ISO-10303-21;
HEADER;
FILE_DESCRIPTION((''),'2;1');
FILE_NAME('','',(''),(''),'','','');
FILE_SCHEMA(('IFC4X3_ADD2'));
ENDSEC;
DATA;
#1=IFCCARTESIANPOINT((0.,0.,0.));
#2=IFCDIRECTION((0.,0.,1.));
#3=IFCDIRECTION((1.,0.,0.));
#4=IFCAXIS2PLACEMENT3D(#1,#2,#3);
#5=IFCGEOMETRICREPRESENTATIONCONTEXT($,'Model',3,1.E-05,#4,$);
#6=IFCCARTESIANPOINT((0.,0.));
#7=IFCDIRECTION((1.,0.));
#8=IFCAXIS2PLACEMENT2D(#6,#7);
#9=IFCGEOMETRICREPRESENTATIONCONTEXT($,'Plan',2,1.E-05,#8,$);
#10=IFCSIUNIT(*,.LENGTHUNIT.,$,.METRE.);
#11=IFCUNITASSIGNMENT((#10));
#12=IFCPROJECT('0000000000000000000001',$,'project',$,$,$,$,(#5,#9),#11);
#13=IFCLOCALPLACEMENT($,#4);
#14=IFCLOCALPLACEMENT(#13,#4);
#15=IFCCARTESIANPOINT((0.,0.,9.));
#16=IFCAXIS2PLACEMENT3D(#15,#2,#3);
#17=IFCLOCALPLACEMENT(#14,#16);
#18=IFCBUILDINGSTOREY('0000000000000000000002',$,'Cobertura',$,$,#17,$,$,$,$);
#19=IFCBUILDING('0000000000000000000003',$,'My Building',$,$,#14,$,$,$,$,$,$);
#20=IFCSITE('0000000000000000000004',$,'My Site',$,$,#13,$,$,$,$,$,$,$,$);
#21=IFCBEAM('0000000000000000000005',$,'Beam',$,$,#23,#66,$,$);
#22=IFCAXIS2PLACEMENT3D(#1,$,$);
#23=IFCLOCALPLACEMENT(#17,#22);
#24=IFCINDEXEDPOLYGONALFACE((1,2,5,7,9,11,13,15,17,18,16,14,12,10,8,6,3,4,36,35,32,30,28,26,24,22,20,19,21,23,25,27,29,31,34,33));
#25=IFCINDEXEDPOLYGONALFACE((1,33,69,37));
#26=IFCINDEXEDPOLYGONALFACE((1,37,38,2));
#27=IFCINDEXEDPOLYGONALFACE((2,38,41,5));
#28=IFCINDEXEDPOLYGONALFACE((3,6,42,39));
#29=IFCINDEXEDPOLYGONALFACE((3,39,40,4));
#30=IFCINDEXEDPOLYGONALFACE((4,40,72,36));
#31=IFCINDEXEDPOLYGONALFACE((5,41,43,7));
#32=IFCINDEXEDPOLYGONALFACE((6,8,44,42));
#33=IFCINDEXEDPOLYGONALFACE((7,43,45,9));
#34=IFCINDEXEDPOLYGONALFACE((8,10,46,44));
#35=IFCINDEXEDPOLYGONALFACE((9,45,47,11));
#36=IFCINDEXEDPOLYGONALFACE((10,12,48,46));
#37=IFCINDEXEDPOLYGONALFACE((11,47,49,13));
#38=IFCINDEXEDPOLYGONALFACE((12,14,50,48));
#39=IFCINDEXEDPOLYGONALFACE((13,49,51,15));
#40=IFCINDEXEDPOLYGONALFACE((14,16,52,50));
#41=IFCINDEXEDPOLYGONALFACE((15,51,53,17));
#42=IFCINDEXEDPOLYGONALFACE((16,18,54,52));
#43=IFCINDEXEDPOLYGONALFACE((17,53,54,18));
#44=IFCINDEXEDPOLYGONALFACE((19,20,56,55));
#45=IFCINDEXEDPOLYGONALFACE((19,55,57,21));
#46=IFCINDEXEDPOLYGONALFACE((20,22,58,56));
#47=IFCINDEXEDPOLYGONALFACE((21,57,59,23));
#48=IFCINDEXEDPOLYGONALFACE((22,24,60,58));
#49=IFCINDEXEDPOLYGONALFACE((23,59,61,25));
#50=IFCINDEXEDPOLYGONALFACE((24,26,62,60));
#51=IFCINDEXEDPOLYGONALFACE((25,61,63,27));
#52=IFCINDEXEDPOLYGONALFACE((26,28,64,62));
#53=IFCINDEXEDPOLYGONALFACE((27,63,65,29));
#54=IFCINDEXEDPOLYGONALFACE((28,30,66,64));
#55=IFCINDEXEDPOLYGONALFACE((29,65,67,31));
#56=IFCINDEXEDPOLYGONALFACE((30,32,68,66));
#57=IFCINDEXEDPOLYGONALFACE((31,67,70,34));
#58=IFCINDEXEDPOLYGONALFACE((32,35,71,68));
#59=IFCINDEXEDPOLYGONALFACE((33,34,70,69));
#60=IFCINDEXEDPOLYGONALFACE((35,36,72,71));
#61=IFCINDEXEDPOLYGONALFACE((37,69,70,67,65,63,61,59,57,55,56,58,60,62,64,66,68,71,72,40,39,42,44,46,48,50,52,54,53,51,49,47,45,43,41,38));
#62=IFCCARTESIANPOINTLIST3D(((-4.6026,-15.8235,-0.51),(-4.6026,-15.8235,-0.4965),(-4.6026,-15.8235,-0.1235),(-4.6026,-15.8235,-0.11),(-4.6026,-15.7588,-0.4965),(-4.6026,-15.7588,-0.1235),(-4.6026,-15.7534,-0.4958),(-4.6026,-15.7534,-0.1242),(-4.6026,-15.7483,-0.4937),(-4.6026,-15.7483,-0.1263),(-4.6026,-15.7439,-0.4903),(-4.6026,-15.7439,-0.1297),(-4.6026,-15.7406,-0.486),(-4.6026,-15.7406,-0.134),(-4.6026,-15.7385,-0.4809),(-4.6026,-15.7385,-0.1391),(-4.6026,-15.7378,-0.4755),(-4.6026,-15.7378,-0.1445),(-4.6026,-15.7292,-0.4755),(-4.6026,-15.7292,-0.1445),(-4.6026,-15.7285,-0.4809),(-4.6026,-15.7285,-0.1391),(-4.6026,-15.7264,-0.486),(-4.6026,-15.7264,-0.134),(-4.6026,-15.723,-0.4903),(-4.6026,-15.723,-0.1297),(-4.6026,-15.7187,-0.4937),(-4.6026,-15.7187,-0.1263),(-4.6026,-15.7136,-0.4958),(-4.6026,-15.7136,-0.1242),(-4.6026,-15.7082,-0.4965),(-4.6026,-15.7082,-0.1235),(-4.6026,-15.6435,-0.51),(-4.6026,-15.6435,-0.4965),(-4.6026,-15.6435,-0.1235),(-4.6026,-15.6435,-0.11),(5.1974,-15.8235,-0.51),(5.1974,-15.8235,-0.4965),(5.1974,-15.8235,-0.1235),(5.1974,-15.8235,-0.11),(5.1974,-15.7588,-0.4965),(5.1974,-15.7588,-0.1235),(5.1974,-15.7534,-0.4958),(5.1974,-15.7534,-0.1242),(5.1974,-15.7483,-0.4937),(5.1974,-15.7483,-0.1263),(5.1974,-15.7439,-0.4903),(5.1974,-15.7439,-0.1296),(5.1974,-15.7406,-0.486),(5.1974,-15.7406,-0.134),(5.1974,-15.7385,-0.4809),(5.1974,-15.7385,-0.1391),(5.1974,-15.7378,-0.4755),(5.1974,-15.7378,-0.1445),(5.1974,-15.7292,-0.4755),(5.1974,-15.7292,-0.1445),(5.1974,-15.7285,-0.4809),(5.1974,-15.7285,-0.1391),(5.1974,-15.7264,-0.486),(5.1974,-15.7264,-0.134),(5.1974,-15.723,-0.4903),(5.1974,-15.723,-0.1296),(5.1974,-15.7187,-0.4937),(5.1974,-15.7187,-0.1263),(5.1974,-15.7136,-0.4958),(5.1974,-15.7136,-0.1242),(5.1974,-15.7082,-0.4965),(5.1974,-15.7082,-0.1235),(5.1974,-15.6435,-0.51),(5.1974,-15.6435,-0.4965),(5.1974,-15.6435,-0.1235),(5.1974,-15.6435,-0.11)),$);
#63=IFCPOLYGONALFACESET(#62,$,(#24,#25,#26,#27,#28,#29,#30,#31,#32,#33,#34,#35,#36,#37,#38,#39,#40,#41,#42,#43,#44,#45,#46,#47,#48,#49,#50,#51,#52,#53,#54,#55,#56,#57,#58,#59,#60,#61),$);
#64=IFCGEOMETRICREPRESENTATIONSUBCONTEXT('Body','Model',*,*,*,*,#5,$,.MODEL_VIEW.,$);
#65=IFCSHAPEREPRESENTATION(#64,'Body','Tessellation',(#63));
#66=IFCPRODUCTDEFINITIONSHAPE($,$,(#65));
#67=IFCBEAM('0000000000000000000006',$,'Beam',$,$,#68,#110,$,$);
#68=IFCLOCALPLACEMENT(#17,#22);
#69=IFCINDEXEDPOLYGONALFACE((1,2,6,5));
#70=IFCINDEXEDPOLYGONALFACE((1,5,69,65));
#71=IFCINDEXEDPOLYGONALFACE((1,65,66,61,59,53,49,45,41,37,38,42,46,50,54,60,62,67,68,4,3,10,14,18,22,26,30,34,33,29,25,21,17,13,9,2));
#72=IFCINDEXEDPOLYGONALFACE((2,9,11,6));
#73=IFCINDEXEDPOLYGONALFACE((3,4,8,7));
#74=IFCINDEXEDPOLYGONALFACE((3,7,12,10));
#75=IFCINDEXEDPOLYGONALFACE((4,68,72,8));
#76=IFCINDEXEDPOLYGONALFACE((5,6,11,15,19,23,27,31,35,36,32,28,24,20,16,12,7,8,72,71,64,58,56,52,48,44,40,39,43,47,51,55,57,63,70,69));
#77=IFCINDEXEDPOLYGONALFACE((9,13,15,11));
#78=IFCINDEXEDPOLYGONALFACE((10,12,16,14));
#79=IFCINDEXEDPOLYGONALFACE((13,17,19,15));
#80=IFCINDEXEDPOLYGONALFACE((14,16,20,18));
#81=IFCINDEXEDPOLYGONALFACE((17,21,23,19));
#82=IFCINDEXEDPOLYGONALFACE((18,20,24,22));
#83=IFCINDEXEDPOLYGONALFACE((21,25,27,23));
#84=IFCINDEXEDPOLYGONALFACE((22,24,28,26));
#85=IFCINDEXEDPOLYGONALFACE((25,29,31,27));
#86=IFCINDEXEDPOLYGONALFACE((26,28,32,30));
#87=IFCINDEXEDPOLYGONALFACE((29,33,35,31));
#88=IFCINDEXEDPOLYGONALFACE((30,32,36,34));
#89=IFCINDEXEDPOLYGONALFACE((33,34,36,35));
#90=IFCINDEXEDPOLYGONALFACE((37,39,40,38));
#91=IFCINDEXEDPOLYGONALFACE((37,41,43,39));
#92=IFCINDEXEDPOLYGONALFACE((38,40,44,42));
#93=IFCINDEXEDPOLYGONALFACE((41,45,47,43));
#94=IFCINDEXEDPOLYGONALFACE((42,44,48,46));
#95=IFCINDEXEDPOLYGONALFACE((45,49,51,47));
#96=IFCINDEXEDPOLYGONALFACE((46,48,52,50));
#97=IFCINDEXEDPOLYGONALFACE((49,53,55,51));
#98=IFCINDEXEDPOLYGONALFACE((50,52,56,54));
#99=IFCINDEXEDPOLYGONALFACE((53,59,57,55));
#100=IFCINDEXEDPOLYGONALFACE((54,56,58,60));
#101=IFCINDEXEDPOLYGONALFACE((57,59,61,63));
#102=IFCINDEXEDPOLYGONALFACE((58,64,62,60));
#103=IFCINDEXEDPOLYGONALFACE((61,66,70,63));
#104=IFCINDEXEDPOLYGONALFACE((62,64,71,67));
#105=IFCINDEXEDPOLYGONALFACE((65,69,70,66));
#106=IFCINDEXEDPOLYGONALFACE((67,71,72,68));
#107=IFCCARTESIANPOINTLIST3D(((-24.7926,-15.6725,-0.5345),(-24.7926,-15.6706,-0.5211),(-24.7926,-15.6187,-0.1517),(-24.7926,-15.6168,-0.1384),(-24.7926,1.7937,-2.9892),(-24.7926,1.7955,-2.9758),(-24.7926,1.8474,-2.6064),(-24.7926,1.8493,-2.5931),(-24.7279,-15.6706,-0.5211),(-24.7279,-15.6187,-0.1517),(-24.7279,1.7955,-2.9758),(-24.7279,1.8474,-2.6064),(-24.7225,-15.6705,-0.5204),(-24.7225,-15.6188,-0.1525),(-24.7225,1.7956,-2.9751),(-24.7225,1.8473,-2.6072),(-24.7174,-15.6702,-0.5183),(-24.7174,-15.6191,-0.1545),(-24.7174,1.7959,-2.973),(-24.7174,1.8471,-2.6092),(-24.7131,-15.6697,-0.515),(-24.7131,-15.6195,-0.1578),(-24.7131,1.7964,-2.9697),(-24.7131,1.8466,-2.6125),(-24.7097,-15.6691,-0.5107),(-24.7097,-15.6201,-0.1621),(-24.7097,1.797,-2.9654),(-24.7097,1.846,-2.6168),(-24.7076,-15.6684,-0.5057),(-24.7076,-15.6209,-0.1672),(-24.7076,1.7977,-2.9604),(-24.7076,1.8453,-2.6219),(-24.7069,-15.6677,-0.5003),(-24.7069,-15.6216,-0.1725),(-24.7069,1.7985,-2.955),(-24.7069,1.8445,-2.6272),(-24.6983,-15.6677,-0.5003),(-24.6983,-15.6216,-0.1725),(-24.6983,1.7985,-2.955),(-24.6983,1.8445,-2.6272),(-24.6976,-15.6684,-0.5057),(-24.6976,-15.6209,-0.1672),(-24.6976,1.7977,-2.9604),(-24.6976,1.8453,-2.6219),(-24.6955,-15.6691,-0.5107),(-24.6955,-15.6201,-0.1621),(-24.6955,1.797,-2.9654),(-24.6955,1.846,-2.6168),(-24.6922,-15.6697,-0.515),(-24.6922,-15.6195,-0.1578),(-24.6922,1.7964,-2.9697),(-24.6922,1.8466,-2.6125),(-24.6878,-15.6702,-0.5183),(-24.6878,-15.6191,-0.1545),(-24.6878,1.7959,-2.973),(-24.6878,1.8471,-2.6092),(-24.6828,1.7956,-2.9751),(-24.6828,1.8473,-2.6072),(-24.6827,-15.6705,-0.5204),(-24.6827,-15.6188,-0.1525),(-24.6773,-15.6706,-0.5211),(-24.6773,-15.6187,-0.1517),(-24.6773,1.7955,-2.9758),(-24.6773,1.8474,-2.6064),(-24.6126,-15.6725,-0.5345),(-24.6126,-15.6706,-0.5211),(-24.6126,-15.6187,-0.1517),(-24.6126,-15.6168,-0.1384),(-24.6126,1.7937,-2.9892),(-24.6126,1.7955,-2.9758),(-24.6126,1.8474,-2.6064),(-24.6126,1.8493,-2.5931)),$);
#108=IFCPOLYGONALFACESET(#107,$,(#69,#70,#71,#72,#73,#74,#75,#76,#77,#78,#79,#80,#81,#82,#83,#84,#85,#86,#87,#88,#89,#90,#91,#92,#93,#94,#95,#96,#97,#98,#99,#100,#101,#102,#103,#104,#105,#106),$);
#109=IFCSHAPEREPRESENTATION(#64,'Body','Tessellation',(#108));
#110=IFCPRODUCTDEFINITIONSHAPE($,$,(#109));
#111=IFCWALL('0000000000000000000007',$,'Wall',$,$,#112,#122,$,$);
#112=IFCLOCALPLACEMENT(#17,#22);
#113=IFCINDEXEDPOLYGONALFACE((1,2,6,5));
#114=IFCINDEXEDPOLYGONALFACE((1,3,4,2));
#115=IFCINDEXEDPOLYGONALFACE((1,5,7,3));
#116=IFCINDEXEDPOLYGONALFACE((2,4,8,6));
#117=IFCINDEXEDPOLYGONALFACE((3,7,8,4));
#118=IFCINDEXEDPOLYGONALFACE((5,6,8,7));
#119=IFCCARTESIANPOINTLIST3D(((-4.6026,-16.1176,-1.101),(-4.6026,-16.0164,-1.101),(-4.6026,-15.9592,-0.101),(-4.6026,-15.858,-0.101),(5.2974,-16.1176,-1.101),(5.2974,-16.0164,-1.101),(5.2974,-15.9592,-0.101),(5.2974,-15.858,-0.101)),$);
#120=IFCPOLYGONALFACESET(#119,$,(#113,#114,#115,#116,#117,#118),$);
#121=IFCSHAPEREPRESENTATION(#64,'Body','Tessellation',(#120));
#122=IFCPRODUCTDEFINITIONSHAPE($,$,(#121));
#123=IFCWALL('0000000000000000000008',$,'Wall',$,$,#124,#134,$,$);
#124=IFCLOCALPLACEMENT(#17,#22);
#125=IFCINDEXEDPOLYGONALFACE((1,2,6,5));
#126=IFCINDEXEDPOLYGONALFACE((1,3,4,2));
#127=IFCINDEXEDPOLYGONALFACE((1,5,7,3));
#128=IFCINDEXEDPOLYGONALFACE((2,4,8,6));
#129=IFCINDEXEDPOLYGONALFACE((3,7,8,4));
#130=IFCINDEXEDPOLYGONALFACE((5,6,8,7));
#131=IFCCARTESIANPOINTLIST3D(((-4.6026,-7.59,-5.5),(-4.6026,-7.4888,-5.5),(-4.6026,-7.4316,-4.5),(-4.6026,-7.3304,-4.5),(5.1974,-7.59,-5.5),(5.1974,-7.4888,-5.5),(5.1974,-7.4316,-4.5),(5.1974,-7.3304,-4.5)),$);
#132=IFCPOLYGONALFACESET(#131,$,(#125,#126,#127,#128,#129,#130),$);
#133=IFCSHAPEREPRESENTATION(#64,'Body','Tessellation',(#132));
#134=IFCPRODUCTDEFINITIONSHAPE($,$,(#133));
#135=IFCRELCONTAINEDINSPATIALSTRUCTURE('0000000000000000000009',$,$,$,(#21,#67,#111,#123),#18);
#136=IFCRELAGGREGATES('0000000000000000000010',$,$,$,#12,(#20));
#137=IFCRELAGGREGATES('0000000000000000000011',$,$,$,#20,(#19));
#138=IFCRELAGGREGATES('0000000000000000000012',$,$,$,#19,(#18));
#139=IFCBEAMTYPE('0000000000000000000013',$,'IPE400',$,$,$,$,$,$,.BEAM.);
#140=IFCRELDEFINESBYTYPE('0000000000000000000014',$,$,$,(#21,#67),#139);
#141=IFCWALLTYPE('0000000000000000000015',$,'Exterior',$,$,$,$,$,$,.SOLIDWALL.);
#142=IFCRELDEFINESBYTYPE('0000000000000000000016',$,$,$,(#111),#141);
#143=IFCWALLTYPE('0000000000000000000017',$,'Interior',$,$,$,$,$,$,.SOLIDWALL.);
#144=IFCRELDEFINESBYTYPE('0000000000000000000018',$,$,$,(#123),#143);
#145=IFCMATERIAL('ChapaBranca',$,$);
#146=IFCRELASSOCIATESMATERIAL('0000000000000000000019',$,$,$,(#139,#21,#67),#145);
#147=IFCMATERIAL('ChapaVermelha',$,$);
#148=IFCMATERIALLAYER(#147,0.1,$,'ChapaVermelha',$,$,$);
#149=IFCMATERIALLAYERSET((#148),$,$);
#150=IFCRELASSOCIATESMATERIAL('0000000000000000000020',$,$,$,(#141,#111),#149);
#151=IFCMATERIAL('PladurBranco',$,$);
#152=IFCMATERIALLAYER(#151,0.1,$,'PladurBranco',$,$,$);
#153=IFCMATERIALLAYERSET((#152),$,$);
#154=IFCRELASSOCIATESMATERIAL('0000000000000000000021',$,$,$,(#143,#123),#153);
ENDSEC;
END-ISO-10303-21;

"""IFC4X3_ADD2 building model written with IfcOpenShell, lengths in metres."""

from ifc_helpers import new_model, si_unit, frame, origin_with_axes, origin_2d_with_axis, place, context, subcontext, project, spatial, line, indexed_curve, i_section, outline, extrude, boolean, material, layer, layer_set, layer_usage, material_profile, profile_set, profile_usage, type_object, element, save


model = new_model("IFC4X3_ADD2")

# Units and contexts
model_context = context("Model", 3, precision=1e-05, world=origin_with_axes())
plan_context = context("Plan", 2, precision=1e-05, world=origin_2d_with_axis())
body_context = subcontext(model_context, "Body", "Model", "MODEL_VIEW")
ifc_project = project(units=[si_unit("LENGTHUNIT", "METRE")], contexts=[model_context, plan_context])

# Site, building, storey
site_placement = place(None, origin_with_axes())
site = spatial("IfcSite", under=ifc_project, at=site_placement, Name="My Site")
building_placement = place(site_placement, origin_with_axes())
building = spatial("IfcBuilding", under=site, at=building_placement, Name="My Building")
storey_placement = place(building_placement, frame((0.0, 0.0, 9.0), z_axis=(0.0, 0.0, 1.0), x_axis=(1.0, 0.0, 0.0)))
storey = spatial("IfcBuildingStorey", under=building, at=storey_placement, Name="Cobertura")

# Beams
ifc_material_1 = material(Name="ChapaBranca")
ifc_material_profile = material_profile(ifc_material_1, i_section(OverallWidth=0.18, OverallDepth=0.4, WebThickness=0.0086, FlangeThickness=0.0135, FilletRadius=0.021))
ifc_profile_set = profile_set([ifc_material_profile])
ifc_profile_usage_1 = profile_usage(ifc_profile_set, cardinal=8)
beam_type = type_object("IfcBeamType", Name="IPE400", PredefinedType="BEAM", material=ifc_profile_set)
beam_1_placement = place(storey_placement, frame((-4.6026, -15.7335, -0.11), z_axis=(1.0, -0.000001, 0.000001), x_axis=(0.000001, 1.0, 0.0)))
element("IfcBeam", 1, at=beam_1_placement, inside=storey, type_object=beam_type, material=ifc_profile_usage_1, Name="Beam", context=body_context, shape_type="SweptSolid", body=[
    extrude(i_section(OverallWidth=0.18, OverallDepth=0.4, WebThickness=0.0086, FlangeThickness=0.0135, FilletRadius=0.021), frame((0.0, -0.2, 0.0), z_axis=(0.0, 0.0, 1.0), x_axis=(1.0, 0.0, 0.0)), (0.0, 0.0, 1.0), 9.8),
])
ifc_profile_usage_2 = profile_usage(ifc_profile_set, cardinal=8)
beam_2_placement = place(storey_placement, frame((-24.7026, -15.6168, -0.1384), z_axis=(0.0, 0.990268, -0.139173), x_axis=(-1.0, 0.0, 0.0)))
element("IfcBeam", 2, at=beam_2_placement, inside=storey, type_object=beam_type, material=ifc_profile_usage_2, Name="Beam", context=body_context, shape_type="SweptSolid", body=[
    extrude(i_section(OverallWidth=0.18, OverallDepth=0.4, WebThickness=0.0086, FlangeThickness=0.0135, FilletRadius=0.021), frame((0.0, -0.2, 0.0), z_axis=(0.0, 0.0, 1.0), x_axis=(1.0, 0.0, 0.0)), (0.0, 0.0, 1.0), 17.6378),
])

# Walls, openings
ifc_material_2 = material(Name="ChapaVermelha")
ifc_layer_1 = layer(ifc_material_2, 0.1, Name="ChapaVermelha")
ifc_layer_set_1 = layer_set([ifc_layer_1])
ifc_layer_usage_1 = layer_usage(ifc_layer_set_1, "AXIS2", "POSITIVE", 0.0)
wall_type_1 = type_object("IfcWallType", Name="Exterior", PredefinedType="SOLIDWALL", material=ifc_layer_set_1)
wall_1_placement = place(storey_placement, frame((-4.7026, -16.1176, -1.101), z_axis=(0.0, 0.0, 1.0), x_axis=(1.0, 0.0, 0.0)))
wall_1 = element("IfcWall", 3, at=wall_1_placement, inside=storey, type_object=wall_type_1, material=ifc_layer_usage_1, Name="Wall", context=body_context, shape_type="CSG", body=[
    boolean("DIFFERENCE", extrude(outline(indexed_curve([(0.1, 0.0), (0.1, 0.1012), (10.0, 0.1012), (10.0, 0.0)], segments=[line(1, 2, 3, 4, 1)])), origin_with_axes(), (0.0, 0.156434, 0.987688), 1.0125), extrude(outline(indexed_curve([(0.1, 0.0), (0.1, 0.1012), (0.1, 0.1012), (0.1, 0.0)], segments=[line(1, 2, 3, 4, 1)])), origin_with_axes(), (0.0, 0.156434, 0.987688), 1.0125)),
])
opening_1_placement = place(wall_1_placement, frame((0.3725, 5.154, 2.6), z_axis=(0.0, 0.0, 1.0), x_axis=(1.0, 0.0, 0.0)))
element("IfcOpeningElement", 4, at=opening_1_placement, cuts=wall_1, PredefinedType="OPENING", context=body_context, shape_type="SweptSolid", body=[
    extrude(outline(indexed_curve([(0.0, 0.0), (0.5, 0.0), (0.5, 0.5), (0.0, 0.5)], segments=[line(1, 2, 3, 4, 1)])), frame((0.0, -0.25, 0.0), z_axis=(0.0, 1.0, 0.0), x_axis=(1.0, 0.0, 0.0)), (0.0, 0.0, 1.0), 0.5),
])
ifc_material_3 = material(Name="PladurBranco")
ifc_layer_2 = layer(ifc_material_3, 0.1, Name="PladurBranco")
ifc_layer_set_2 = layer_set([ifc_layer_2])
ifc_layer_usage_2 = layer_usage(ifc_layer_set_2, "AXIS2", "POSITIVE", 0.0)
wall_type_2 = type_object("IfcWallType", Name="Interior", PredefinedType="SOLIDWALL", material=ifc_layer_set_2)
wall_2_placement = place(storey_placement, frame((-4.6026, -7.59, -5.5), z_axis=(0.0, 0.0, 1.0), x_axis=(1.0, 0.0, 0.0)))
wall_2 = element("IfcWall", 5, at=wall_2_placement, inside=storey, type_object=wall_type_2, material=ifc_layer_usage_2, Name="Wall", context=body_context, shape_type="SweptSolid", body=[
    extrude(outline(indexed_curve([(0.0, 0.0), (0.0, 0.1012), (9.8, 0.1012), (9.8, 0.0)], segments=[line(1, 2, 3, 4, 1)])), origin_with_axes(), (0.0, 0.156434, 0.987688), 1.0125),
])
opening_2_placement = place(wall_2_placement, frame((0.3725, 5.154, 2.6), z_axis=(0.0, 0.0, 1.0), x_axis=(1.0, 0.0, 0.0)))
element("IfcOpeningElement", 6, at=opening_2_placement, cuts=wall_2, PredefinedType="OPENING", context=body_context, shape_type="SweptSolid", body=[
    extrude(outline(indexed_curve([(0.0, 0.0), (0.5, 0.0), (0.5, 0.5), (0.0, 0.5)], segments=[line(1, 2, 3, 4, 1)])), frame((0.0, -0.25, 0.0), z_axis=(0.0, 1.0, 0.0), x_axis=(1.0, 0.0, 0.0)), (0.0, 0.0, 1.0), 0.5),
])

save(model, "model.ifc")
